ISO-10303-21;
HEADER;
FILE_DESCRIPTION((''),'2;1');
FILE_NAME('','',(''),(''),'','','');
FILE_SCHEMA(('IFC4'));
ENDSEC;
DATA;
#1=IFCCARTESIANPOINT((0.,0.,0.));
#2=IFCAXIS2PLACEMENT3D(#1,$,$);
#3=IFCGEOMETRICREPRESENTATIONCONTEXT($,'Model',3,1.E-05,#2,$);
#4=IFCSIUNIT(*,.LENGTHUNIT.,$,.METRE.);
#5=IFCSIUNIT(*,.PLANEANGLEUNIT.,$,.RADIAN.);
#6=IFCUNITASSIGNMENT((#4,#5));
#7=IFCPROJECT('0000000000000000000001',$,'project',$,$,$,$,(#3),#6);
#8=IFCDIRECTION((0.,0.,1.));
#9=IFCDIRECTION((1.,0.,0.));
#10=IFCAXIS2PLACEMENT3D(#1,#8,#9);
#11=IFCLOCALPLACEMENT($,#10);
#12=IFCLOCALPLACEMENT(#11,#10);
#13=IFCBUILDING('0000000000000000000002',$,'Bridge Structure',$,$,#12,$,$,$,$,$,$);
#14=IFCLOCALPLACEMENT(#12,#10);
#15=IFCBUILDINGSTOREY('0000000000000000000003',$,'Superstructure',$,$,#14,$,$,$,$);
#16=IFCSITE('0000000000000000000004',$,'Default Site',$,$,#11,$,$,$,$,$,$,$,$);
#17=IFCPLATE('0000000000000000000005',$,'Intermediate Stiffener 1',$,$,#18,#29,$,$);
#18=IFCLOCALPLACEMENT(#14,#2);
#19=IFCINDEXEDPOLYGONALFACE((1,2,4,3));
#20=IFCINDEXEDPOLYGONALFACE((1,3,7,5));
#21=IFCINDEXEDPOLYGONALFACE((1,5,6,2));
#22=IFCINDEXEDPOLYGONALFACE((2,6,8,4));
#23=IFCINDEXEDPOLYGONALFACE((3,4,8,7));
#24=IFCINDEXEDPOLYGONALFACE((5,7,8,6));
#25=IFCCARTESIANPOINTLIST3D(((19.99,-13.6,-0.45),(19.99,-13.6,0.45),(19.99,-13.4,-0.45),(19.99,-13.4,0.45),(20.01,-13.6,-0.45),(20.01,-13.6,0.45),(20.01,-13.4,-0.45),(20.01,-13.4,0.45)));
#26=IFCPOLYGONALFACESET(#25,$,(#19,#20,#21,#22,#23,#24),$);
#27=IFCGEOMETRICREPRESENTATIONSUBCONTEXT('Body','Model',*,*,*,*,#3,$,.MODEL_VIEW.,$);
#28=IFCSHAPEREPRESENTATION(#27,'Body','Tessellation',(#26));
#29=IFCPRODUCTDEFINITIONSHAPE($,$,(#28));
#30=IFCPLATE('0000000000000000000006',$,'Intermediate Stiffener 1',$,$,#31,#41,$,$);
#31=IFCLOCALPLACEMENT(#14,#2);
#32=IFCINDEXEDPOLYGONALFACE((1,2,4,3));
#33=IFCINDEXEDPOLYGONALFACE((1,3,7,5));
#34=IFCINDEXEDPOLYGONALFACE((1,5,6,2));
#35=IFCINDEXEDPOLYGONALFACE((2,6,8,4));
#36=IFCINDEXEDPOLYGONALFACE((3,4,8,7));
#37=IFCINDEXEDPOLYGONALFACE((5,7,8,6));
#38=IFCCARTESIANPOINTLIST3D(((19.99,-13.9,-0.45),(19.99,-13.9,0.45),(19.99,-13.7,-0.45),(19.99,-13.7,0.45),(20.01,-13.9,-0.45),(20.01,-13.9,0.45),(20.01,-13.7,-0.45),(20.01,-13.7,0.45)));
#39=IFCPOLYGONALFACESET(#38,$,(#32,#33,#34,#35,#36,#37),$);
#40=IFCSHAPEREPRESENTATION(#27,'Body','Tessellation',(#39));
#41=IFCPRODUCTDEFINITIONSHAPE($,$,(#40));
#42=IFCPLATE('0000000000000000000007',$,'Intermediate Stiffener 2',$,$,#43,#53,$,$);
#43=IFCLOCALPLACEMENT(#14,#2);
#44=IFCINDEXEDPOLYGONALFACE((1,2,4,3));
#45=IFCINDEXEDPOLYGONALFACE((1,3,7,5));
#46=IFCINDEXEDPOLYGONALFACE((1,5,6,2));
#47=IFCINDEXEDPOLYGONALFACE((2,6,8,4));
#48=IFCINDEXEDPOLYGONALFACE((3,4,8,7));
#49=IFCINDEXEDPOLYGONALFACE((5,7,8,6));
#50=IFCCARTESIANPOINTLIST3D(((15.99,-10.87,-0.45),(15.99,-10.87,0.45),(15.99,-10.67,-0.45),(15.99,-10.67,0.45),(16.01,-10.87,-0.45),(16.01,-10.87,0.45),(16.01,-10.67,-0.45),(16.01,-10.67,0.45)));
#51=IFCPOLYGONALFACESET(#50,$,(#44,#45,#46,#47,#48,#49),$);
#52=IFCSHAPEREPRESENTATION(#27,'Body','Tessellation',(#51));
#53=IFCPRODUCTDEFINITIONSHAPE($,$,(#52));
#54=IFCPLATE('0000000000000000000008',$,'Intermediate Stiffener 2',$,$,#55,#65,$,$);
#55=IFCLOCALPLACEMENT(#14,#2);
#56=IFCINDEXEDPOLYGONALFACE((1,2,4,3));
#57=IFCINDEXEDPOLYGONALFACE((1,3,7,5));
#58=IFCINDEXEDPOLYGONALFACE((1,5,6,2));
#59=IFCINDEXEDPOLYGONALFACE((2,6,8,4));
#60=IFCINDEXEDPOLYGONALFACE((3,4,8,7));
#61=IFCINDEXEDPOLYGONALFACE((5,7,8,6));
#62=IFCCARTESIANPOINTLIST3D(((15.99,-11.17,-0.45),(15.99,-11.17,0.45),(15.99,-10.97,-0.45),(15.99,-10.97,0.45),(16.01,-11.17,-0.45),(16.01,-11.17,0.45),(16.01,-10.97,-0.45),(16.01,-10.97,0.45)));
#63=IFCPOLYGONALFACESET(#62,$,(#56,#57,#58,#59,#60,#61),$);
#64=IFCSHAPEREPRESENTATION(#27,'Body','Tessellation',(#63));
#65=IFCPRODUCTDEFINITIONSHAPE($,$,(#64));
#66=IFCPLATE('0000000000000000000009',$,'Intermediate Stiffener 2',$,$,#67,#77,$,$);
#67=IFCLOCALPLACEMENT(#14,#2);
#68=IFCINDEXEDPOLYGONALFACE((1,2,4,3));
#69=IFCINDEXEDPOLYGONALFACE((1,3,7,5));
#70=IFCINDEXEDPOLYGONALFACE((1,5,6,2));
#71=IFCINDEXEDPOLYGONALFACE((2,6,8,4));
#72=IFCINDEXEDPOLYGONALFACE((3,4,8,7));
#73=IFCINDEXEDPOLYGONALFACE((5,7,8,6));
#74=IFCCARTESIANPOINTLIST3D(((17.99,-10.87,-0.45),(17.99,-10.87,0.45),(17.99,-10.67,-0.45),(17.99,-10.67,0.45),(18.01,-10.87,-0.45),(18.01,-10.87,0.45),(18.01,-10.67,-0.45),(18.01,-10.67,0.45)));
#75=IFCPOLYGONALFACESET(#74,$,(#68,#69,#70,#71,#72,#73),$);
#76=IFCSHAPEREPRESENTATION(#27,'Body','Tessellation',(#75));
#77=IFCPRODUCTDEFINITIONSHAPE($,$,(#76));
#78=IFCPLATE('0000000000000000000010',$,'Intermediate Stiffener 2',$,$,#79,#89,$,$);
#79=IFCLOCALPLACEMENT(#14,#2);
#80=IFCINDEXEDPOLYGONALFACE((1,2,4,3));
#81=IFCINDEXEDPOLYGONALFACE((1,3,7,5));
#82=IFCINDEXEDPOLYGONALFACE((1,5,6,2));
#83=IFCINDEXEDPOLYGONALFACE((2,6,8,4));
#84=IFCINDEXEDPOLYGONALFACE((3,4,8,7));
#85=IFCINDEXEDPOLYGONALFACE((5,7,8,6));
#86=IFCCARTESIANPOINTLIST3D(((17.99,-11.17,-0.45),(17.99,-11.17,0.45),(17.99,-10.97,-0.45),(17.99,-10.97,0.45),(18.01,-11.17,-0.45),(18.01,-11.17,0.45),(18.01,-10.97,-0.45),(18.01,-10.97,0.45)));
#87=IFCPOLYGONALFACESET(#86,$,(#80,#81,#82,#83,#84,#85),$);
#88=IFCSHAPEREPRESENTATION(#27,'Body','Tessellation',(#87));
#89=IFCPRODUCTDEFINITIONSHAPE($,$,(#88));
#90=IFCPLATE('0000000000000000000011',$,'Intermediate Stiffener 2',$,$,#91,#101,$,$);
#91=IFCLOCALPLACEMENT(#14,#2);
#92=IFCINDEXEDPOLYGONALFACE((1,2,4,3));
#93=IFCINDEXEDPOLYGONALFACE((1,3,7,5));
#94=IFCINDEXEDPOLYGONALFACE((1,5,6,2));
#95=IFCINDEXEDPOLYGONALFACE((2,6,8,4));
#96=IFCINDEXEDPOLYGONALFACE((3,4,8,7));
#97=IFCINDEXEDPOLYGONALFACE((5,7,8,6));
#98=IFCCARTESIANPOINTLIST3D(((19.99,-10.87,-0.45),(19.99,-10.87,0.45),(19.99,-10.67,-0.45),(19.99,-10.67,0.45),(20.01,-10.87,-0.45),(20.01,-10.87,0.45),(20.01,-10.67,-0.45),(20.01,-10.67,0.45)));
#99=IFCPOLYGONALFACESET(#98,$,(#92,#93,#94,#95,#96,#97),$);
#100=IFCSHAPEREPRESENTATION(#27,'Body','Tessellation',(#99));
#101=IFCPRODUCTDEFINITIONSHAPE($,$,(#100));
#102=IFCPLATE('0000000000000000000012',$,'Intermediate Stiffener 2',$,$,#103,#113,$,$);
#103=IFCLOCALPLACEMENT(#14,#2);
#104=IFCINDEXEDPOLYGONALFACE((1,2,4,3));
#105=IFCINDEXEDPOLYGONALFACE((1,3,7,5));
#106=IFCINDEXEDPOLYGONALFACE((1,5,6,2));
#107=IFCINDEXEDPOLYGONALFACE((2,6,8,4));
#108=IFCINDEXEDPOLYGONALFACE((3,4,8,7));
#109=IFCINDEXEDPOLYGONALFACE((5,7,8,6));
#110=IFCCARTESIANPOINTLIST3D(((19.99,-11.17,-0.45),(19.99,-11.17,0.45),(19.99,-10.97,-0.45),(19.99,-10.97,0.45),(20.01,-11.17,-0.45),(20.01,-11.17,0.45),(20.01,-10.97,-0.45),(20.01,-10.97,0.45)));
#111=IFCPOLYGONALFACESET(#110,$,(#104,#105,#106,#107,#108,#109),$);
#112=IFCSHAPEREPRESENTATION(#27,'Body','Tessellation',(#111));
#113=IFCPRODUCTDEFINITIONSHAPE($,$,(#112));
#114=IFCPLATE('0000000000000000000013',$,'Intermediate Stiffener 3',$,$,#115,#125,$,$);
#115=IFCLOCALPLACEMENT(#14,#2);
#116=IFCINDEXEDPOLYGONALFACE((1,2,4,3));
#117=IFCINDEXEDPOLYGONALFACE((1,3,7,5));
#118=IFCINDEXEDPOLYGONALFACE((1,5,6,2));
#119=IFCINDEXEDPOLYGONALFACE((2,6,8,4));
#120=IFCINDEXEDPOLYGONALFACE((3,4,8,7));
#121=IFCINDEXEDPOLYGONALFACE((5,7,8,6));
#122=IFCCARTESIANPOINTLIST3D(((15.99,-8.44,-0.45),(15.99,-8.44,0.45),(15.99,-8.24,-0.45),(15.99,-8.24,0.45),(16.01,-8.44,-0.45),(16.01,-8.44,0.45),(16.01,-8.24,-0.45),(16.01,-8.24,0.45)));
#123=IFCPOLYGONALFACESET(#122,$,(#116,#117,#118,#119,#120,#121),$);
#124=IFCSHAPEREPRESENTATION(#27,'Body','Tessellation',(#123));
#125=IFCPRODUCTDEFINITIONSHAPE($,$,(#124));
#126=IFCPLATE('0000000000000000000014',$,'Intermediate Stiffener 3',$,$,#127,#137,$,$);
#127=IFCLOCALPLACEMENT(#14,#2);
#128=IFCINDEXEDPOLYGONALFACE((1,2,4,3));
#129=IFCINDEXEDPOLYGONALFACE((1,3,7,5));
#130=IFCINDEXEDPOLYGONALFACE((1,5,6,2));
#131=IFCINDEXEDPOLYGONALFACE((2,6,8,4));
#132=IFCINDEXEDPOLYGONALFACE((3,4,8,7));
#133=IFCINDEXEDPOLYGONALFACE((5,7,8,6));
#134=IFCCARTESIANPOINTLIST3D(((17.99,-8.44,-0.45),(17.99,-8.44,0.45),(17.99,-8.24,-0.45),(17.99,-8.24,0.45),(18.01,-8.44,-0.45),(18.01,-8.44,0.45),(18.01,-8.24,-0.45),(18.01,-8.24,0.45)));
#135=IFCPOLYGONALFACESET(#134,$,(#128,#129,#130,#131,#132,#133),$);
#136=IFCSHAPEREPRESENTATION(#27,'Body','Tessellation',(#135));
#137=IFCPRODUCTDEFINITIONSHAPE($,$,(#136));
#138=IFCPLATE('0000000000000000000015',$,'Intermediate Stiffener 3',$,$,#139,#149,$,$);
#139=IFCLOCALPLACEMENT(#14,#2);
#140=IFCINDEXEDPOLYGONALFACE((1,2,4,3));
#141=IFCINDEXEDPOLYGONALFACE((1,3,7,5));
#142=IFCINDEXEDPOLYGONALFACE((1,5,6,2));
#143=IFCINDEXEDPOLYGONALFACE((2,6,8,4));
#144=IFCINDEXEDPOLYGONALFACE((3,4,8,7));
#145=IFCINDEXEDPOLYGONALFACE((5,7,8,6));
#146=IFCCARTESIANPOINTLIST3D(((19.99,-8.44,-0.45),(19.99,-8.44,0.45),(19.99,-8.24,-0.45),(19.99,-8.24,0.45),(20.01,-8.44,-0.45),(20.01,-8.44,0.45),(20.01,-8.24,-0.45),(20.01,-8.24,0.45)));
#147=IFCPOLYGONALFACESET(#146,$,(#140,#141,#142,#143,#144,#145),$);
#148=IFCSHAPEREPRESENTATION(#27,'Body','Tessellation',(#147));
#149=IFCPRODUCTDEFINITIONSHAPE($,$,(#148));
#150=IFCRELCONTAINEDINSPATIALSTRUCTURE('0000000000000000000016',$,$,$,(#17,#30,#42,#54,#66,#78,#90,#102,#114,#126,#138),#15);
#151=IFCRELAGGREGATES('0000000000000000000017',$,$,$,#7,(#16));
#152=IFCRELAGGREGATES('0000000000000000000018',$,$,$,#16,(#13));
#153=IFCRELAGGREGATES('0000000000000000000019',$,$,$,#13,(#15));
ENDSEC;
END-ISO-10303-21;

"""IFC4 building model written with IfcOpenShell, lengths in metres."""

from ifc_helpers import new_model, si_unit, frame, origin, origin_with_axes, origin_2d_with_axis, place, context, subcontext, project, spatial, rectangle, extrude, element, save


model = new_model("IFC4")

# Units and contexts
model_context = context("Model", 3, precision=1e-05, world=origin())
body_context = subcontext(model_context, "Body", "Model", "MODEL_VIEW")
ifc_project = project(units=[si_unit("LENGTHUNIT", "METRE"), si_unit("PLANEANGLEUNIT", "RADIAN")], contexts=[model_context])

# Site, building, storey
site_placement = place(None, origin_with_axes())
site = spatial("IfcSite", under=ifc_project, at=site_placement, Name="Default Site")
building_placement = place(site_placement, origin_with_axes())
building = spatial("IfcBuilding", under=site, at=building_placement, Name="Bridge Structure")
storey_placement = place(building_placement, origin_with_axes())
storey = spatial("IfcBuildingStorey", under=building, at=storey_placement, Name="Superstructure")

# Plates
for number, where, z_axis, x_axis, name in (
    (1, (20.0, -13.5, -0.45), (0.0, 0.0, 1.0), (1.0, 0.0, 0.0), "Intermediate Stiffener 1"),
    (2, (20.0, -13.8, -0.45), (0.0, 0.0, 1.0), (1.0, 0.0, 0.0), "Intermediate Stiffener 1"),
    (3, (16.0, -10.77, -0.45), (0.0, 0.0, 1.0), (1.0, 0.0, 0.0), "Intermediate Stiffener 2"),
    (4, (16.0, -11.07, -0.45), (0.0, 0.0, 1.0), (1.0, 0.0, 0.0), "Intermediate Stiffener 2"),
    (5, (18.0, -10.77, -0.45), (0.0, 0.0, 1.0), (1.0, 0.0, 0.0), "Intermediate Stiffener 2"),
    (6, (18.0, -11.07, -0.45), (0.0, 0.0, 1.0), (1.0, 0.0, 0.0), "Intermediate Stiffener 2"),
    (7, (20.0, -10.77, -0.45), (0.0, 0.0, 1.0), (1.0, 0.0, 0.0), "Intermediate Stiffener 2"),
    (8, (20.0, -11.07, -0.45), (0.0, 0.0, 1.0), (1.0, 0.0, 0.0), "Intermediate Stiffener 2"),
    (9, (16.0, -8.34, -0.45), (0.0, 0.0, 1.0), (1.0, 0.0, 0.0), "Intermediate Stiffener 3"),
    (10, (18.0, -8.34, -0.45), (0.0, 0.0, 1.0), (1.0, 0.0, 0.0), "Intermediate Stiffener 3"),
    (11, (20.0, -8.34, -0.45), (0.0, 0.0, 1.0), (1.0, 0.0, 0.0), "Intermediate Stiffener 3"),
):
    element("IfcPlate", number, at=place(storey_placement, frame(where, z_axis=z_axis, x_axis=x_axis)), inside=storey, Name=name, context=body_context, shape_type="SweptSolid", body=[
        extrude(rectangle(XDim=0.02, YDim=0.2, at=origin_2d_with_axis()), origin_with_axes(), (0.0, 0.0, 1.0), 0.9),
    ])

save(model, "model.ifc")
